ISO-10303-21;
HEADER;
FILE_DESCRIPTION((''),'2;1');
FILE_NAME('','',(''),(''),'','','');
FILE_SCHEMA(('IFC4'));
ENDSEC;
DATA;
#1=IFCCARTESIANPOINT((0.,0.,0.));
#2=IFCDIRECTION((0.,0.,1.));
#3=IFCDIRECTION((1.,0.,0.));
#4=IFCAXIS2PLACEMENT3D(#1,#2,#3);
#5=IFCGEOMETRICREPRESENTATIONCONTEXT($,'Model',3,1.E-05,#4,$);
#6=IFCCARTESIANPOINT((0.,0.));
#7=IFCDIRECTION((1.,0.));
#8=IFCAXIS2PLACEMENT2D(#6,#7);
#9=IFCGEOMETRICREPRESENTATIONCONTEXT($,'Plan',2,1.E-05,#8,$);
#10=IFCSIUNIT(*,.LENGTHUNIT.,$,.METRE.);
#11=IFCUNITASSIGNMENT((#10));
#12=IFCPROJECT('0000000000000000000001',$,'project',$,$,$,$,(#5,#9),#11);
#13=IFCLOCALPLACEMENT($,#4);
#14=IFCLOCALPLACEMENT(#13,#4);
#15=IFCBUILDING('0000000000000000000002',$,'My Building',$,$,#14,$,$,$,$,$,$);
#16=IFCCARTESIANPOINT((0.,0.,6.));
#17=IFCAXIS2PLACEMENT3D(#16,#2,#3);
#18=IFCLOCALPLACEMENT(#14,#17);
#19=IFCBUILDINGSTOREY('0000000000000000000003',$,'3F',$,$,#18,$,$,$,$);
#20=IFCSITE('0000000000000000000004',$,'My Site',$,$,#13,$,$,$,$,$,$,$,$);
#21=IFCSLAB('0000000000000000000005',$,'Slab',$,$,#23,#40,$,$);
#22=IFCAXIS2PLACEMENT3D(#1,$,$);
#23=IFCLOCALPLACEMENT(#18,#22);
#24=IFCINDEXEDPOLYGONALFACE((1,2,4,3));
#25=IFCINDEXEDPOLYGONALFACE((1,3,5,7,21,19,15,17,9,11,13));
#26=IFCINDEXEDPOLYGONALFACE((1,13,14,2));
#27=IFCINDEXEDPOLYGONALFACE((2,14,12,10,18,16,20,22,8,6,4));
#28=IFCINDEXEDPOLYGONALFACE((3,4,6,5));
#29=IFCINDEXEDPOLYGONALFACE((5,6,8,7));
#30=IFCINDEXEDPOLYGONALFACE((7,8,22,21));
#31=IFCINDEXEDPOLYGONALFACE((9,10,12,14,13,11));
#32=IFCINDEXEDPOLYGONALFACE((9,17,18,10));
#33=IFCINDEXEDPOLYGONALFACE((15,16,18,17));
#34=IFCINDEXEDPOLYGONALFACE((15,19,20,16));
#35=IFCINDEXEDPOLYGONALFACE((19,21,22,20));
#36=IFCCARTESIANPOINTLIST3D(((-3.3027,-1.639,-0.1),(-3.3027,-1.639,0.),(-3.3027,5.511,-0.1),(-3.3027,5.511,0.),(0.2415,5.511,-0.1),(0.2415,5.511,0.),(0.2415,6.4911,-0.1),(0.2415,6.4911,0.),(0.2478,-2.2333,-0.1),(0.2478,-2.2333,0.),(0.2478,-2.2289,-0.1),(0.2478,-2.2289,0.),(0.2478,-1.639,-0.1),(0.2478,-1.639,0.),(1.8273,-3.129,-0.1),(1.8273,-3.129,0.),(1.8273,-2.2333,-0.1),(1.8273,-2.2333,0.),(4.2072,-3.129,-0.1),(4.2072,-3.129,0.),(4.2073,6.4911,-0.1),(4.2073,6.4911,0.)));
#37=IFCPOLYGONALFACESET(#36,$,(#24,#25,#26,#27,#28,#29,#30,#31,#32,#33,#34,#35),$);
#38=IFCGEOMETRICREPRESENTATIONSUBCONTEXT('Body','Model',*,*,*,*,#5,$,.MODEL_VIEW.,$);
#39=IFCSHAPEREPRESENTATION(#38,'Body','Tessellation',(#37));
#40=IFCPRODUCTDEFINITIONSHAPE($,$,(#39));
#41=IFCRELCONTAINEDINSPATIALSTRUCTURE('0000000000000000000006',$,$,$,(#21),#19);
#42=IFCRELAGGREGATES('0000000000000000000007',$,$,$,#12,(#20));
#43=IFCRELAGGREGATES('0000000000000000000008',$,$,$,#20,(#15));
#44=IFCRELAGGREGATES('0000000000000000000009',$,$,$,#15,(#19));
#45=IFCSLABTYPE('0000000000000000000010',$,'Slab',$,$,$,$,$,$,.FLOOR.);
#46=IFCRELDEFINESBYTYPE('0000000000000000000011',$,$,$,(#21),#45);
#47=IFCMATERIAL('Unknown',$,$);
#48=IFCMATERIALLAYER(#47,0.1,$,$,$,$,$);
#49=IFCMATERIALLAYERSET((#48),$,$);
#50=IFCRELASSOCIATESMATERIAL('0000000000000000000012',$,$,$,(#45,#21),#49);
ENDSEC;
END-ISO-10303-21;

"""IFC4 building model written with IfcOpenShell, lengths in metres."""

from ifc_helpers import new_model, si_unit, frame, origin_with_axes, origin_2d_with_axis, place, context, subcontext, project, spatial, indexed_curve, outline, extrude, material, layer, layer_set, layer_usage, type_object, element, save


model = new_model("IFC4")

# Units and contexts
model_context = context("Model", 3, precision=1e-05, world=origin_with_axes())
plan_context = context("Plan", 2, precision=1e-05, world=origin_2d_with_axis())
body_context = subcontext(model_context, "Body", "Model", "MODEL_VIEW")
ifc_project = project(units=[si_unit("LENGTHUNIT", "METRE")], contexts=[model_context, plan_context])

# Site, building, storey
site_placement = place(None, origin_with_axes())
site = spatial("IfcSite", under=ifc_project, at=site_placement, Name="My Site")
building_placement = place(site_placement, origin_with_axes())
building = spatial("IfcBuilding", under=site, at=building_placement, Name="My Building")
storey_placement = place(building_placement, frame((0.0, 0.0, 6.0), z_axis=(0.0, 0.0, 1.0), x_axis=(1.0, 0.0, 0.0)))
storey = spatial("IfcBuildingStorey", under=building, at=storey_placement, Name="3F")

# Slab
ifc_material = material(Name="Unknown")
ifc_layer = layer(ifc_material, 0.1)
ifc_layer_set = layer_set([ifc_layer])
ifc_layer_usage = layer_usage(ifc_layer_set, "AXIS3", "POSITIVE", -0.1)
slab_type = type_object("IfcSlabType", Name="Slab", PredefinedType="FLOOR", material=ifc_layer_set)
slab_placement = place(storey_placement, frame((4.2073, 6.4911, 0.0), z_axis=(0.0, 0.0, 1.0), x_axis=(1.0, 0.0, 0.0)))
element("IfcSlab", 1, at=slab_placement, inside=storey, type_object=slab_type, material=ifc_layer_usage, Name="Slab", context=body_context, shape_type="SweptSolid", body=[
    extrude(outline(indexed_curve([(0.0, 0.0), (-3.9658, 0.0), (-3.9658, -0.9801), (-7.51, -0.9801), (-7.51, -8.13), (-3.9595, -8.13), (-3.9595, -8.72), (-3.9595, -8.7244), (-2.38, -8.7244), (-2.38, -9.62), (-0.0001, -9.62), (0.0, 0.0)])), frame((0.0, 0.0, -0.1), z_axis=(0.0, 0.0, 1.0), x_axis=(1.0, 0.0, 0.0)), (0.0, 0.0, 1.0), 0.1),
])

save(model, "model.ifc")
